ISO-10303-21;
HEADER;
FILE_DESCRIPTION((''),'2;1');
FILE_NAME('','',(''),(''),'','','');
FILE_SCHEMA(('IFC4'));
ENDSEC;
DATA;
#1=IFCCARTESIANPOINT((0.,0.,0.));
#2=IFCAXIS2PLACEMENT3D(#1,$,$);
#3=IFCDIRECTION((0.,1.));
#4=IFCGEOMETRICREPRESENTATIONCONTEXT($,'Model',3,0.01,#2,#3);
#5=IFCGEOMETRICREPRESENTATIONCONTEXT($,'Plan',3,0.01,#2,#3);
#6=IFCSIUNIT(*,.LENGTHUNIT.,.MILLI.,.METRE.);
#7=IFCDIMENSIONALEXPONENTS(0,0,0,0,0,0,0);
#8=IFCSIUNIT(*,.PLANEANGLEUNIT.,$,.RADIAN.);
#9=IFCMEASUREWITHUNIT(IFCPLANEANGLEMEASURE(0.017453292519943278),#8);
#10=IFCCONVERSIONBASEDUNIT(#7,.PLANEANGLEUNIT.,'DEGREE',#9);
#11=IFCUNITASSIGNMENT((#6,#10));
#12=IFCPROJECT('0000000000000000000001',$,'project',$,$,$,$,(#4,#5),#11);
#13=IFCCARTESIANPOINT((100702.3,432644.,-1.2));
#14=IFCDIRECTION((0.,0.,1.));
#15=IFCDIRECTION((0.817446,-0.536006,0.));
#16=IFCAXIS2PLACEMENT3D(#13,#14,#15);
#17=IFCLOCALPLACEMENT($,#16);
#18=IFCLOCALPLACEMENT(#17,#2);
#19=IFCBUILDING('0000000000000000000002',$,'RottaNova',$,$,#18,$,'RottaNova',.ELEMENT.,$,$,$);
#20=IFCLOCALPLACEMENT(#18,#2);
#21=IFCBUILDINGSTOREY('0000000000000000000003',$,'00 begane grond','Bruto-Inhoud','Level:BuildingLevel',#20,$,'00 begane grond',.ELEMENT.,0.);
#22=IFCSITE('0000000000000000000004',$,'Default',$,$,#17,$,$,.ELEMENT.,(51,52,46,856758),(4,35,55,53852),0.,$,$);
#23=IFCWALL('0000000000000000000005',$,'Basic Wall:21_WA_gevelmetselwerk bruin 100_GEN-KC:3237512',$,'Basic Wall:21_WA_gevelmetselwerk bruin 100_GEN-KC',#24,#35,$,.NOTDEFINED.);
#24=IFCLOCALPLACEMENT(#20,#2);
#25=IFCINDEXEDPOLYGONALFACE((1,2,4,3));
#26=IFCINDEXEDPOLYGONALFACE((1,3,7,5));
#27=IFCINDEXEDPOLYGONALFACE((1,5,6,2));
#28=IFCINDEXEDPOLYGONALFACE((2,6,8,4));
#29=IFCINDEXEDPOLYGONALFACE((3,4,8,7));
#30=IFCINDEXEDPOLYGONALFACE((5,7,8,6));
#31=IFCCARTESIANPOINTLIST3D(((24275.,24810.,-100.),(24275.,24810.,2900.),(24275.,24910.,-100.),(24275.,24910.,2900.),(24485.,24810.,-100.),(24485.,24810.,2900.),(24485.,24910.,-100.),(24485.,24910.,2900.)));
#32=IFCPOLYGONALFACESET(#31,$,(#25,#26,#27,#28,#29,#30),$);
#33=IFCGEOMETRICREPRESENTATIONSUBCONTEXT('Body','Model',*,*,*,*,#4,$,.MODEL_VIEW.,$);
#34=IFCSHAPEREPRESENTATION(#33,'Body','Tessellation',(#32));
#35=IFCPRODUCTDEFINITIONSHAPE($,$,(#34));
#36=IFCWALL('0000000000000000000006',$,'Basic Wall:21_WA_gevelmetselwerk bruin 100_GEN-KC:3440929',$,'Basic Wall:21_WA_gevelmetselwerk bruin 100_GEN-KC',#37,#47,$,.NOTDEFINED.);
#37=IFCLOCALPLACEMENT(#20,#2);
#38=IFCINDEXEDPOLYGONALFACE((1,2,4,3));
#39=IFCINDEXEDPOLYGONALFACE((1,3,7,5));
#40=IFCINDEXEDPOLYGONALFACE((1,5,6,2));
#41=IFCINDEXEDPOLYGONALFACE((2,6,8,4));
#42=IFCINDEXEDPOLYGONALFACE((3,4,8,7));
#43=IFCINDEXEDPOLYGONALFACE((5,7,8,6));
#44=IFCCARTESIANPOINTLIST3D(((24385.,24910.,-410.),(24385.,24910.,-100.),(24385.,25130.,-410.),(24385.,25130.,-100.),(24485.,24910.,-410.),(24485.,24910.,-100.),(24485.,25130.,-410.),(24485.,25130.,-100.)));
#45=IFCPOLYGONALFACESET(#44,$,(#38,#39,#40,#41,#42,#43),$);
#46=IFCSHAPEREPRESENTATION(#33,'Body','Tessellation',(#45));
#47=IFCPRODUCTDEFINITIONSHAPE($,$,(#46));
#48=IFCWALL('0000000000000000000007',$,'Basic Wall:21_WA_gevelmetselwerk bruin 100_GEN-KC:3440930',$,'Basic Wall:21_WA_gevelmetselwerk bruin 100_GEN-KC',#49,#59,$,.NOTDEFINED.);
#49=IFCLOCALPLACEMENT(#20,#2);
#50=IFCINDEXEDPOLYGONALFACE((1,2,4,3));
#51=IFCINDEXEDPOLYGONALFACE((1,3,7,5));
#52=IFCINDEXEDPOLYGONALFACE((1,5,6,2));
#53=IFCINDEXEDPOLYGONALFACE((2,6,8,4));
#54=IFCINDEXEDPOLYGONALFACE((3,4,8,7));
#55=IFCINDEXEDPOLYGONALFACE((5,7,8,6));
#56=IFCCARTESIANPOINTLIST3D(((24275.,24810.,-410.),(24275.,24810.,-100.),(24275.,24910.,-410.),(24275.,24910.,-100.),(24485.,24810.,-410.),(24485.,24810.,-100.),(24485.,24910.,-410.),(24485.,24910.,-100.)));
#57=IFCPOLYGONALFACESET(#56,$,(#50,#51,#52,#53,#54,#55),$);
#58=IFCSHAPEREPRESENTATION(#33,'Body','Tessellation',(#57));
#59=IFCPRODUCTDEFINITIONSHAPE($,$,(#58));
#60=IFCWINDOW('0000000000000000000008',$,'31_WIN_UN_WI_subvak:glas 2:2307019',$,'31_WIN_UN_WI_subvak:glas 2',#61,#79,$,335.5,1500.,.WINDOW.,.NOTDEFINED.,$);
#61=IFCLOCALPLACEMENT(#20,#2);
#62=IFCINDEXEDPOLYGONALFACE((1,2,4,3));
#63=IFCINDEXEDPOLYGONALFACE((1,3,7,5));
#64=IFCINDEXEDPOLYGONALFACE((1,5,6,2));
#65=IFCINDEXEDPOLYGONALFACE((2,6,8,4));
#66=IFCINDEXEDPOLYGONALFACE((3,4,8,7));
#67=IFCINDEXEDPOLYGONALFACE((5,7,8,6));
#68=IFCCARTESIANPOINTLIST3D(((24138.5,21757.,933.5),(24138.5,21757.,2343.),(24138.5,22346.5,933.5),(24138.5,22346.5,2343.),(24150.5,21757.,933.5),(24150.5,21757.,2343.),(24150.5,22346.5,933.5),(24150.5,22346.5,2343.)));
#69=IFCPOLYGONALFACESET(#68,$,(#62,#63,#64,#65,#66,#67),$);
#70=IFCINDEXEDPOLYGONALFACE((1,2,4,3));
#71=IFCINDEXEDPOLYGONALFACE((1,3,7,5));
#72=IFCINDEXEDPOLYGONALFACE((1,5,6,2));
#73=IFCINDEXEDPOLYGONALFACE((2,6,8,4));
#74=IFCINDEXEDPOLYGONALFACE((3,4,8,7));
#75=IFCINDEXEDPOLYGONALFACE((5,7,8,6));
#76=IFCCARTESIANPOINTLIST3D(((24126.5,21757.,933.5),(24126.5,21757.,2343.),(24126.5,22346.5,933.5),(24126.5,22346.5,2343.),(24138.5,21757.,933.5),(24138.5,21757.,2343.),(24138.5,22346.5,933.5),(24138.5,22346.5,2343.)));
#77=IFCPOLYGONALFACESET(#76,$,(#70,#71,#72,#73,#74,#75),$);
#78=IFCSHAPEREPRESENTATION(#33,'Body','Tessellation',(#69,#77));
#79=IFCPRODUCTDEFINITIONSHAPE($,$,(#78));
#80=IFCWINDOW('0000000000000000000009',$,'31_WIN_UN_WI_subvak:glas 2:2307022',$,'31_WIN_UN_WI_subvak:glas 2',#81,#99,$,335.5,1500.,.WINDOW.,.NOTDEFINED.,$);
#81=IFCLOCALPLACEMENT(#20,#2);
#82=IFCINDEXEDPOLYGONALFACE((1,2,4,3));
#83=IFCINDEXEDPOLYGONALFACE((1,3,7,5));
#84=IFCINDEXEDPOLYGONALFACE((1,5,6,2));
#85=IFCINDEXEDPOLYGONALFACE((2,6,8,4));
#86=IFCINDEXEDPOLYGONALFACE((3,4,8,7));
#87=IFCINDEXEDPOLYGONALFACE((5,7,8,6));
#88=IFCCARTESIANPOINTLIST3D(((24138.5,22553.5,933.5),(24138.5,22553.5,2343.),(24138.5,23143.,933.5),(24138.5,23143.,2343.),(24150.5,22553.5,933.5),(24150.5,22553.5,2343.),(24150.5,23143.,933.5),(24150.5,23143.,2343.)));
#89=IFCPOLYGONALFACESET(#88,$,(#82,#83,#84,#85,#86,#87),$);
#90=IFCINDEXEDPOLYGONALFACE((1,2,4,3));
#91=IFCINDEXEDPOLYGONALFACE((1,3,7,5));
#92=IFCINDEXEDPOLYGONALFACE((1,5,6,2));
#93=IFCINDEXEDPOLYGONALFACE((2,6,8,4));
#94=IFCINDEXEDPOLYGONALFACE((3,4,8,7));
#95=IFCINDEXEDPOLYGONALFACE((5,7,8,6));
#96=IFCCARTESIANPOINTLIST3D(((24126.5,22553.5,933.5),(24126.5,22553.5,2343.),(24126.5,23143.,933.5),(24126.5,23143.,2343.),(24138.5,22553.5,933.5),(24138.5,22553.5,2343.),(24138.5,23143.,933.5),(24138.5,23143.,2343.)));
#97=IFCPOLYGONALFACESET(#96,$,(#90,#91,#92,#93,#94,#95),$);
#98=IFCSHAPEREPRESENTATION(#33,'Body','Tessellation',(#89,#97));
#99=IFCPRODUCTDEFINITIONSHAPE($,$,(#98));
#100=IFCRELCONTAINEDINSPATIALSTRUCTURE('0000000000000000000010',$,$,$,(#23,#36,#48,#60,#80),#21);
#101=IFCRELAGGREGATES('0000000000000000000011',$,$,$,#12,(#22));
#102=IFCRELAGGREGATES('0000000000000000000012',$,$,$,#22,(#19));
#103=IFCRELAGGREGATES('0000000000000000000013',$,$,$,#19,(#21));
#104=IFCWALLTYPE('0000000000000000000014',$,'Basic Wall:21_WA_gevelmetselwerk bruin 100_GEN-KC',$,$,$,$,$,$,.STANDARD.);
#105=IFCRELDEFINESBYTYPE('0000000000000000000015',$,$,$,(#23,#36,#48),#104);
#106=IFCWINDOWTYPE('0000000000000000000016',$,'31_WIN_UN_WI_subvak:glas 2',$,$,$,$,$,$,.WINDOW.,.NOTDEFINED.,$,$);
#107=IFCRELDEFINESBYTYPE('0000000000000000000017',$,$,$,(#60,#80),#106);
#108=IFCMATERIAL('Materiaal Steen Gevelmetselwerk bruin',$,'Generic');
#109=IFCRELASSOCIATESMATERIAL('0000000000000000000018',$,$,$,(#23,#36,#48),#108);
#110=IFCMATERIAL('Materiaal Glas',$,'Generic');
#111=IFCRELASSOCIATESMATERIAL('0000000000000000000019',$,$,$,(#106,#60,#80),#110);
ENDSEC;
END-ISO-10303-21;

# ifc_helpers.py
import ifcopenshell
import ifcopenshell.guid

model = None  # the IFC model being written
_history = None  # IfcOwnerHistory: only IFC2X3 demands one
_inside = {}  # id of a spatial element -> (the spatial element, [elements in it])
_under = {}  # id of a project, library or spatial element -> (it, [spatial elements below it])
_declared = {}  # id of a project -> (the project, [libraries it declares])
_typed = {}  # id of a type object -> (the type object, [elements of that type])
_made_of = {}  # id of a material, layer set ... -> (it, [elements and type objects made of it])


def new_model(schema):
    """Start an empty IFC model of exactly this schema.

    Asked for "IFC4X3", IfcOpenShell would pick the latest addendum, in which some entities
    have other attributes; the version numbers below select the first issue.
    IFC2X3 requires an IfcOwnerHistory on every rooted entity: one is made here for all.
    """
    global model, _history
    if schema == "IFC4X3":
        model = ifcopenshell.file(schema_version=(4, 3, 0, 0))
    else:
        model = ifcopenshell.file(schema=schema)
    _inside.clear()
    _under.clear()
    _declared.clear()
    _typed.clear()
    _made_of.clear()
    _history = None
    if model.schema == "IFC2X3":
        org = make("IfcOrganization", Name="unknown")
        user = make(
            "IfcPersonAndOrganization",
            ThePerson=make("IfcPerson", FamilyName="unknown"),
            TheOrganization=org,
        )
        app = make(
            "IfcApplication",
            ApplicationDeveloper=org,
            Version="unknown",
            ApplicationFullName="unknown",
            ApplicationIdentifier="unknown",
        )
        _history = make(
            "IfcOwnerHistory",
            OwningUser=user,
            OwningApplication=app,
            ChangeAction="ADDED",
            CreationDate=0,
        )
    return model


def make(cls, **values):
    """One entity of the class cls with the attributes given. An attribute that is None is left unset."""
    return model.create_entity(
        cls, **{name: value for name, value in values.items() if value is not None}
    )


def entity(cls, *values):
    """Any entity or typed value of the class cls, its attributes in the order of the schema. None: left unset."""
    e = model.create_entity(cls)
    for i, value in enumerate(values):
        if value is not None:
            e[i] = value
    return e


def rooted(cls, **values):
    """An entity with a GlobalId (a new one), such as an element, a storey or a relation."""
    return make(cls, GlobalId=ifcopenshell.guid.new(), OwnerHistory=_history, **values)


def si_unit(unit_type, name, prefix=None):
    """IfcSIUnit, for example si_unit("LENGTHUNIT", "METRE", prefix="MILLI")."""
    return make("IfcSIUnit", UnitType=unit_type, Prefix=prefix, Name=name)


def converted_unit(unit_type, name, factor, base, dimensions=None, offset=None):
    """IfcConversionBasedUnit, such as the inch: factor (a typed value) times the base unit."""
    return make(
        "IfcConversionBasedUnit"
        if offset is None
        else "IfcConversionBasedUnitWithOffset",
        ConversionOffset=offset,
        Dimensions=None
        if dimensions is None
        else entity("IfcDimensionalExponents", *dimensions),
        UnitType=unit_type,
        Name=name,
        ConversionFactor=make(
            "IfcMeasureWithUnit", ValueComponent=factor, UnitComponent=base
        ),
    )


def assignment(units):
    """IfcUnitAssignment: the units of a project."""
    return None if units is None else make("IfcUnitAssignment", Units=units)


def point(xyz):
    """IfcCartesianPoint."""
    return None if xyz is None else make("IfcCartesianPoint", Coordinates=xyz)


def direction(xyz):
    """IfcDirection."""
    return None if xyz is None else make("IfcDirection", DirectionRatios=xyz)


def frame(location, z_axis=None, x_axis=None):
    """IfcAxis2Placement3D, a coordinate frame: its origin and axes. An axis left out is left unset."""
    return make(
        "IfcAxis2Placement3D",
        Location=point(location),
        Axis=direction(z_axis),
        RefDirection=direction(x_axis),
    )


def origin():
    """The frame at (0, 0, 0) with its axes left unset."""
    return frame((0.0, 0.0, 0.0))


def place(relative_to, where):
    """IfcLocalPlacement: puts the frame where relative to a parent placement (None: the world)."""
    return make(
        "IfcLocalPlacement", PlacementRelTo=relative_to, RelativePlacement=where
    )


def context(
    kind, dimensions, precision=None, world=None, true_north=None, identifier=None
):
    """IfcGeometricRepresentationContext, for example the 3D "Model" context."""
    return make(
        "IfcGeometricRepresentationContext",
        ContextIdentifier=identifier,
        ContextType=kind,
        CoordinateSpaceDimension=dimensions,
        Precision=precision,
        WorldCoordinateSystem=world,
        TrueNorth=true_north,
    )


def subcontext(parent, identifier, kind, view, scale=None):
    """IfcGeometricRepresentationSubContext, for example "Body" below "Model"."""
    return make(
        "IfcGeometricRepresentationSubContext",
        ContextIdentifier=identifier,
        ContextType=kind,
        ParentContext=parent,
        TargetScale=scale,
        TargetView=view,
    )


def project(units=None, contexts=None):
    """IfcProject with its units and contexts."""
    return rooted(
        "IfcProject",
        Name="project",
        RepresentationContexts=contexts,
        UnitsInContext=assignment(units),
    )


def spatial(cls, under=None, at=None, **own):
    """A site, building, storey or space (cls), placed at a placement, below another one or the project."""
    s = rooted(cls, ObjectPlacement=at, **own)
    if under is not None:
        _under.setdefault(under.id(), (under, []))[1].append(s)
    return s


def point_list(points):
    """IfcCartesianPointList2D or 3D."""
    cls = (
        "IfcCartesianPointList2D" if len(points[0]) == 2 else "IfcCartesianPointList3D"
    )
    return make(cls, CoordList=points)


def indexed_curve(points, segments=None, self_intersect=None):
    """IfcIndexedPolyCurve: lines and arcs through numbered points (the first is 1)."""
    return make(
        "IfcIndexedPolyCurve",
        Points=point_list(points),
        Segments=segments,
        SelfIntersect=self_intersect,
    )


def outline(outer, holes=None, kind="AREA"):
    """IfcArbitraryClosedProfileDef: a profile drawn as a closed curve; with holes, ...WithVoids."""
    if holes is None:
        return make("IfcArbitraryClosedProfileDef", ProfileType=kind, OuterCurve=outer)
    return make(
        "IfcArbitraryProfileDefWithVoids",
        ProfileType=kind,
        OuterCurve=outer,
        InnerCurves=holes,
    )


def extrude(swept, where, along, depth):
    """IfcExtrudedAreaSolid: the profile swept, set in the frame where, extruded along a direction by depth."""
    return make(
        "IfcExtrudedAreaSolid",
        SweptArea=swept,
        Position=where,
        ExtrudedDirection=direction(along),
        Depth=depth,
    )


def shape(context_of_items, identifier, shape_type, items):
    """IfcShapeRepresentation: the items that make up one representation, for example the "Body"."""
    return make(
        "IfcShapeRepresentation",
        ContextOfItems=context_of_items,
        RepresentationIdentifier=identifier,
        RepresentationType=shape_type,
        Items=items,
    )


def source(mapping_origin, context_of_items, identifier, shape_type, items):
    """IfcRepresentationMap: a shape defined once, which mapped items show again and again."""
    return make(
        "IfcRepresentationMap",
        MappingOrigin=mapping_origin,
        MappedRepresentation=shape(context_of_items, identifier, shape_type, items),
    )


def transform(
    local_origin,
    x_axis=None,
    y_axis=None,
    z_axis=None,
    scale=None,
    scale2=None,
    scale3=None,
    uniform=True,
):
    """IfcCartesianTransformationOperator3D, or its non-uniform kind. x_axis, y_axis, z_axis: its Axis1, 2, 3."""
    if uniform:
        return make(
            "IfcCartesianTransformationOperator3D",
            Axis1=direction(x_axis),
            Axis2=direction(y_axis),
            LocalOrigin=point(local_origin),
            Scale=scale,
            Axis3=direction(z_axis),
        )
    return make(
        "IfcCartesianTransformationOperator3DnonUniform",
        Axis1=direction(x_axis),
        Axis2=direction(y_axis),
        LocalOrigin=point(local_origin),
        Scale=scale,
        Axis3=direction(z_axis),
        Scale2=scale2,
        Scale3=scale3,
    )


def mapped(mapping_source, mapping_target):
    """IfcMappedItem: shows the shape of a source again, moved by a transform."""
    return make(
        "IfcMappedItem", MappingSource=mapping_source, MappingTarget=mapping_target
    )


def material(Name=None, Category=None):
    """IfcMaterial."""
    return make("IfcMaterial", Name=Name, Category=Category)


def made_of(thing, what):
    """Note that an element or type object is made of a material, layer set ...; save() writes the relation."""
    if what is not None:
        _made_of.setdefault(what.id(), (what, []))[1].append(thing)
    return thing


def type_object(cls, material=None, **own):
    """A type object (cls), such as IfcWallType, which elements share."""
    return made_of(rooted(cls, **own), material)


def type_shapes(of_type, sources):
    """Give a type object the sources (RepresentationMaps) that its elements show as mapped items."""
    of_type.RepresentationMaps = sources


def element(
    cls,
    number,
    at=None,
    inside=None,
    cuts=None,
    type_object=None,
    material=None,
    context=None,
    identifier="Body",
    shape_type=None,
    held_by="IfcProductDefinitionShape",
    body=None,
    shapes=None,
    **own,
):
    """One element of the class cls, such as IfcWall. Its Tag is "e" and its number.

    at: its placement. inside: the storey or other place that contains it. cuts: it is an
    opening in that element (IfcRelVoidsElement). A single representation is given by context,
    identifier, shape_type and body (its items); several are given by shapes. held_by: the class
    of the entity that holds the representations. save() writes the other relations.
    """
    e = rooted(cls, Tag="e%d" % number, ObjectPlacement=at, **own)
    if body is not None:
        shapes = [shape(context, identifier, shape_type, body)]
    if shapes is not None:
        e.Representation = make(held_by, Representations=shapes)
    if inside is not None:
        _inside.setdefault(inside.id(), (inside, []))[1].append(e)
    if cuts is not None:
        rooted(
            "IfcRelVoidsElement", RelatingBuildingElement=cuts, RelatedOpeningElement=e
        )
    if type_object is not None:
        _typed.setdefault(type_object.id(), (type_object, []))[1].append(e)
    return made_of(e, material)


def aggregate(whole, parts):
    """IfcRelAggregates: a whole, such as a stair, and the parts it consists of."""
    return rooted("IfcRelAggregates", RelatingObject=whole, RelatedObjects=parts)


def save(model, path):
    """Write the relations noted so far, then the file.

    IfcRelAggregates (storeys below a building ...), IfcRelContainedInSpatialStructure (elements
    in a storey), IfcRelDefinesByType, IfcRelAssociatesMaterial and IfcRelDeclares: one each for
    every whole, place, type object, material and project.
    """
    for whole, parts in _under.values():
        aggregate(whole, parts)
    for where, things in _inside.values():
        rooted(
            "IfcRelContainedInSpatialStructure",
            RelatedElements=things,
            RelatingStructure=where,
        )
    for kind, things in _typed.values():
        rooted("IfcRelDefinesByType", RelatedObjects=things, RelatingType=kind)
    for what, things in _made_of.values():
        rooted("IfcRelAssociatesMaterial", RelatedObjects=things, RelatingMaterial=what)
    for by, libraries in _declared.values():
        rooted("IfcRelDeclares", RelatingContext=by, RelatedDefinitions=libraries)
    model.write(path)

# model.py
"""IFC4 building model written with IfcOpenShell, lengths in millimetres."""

from ifc_helpers import new_model, entity, si_unit, converted_unit, direction, frame, origin, place, context, subcontext, project, spatial, indexed_curve, outline, extrude, source, transform, mapped, material, type_object, type_shapes, element, save


model = new_model("IFC4")

# Units and contexts
model_context = context("Model", 3, precision=0.01, world=origin(), true_north=direction((0.0, 1.0)))
plan_context = context("Plan", 3, precision=0.01, world=origin(), true_north=direction((0.0, 1.0)))
body_context = subcontext(model_context, "Body", "Model", "MODEL_VIEW")
ifc_project = project(units=[si_unit("LENGTHUNIT", "METRE", prefix="MILLI"), converted_unit("PLANEANGLEUNIT", "DEGREE", entity("IfcPlaneAngleMeasure", 0.017453292519943278), si_unit("PLANEANGLEUNIT", "RADIAN"), dimensions=[0, 0, 0, 0, 0, 0, 0])], contexts=[model_context, plan_context])

# Site, building, storey
site_placement = place(None, frame((100702.3, 432644.0, -1.2), z_axis=(0.0, 0.0, 1.0), x_axis=(0.817446, -0.536006, 0.0)))
site = spatial("IfcSite", under=ifc_project, at=site_placement, Name="Default", CompositionType="ELEMENT", RefLatitude=(51, 52, 46, 856758), RefLongitude=(4, 35, 55, 53852), RefElevation=0.0)
building_placement = place(site_placement, origin())
building = spatial("IfcBuilding", under=site, at=building_placement, Name="RottaNova", LongName="RottaNova", CompositionType="ELEMENT")
storey_placement = place(building_placement, origin())
storey = spatial("IfcBuildingStorey", under=building, at=storey_placement, Name="00 begane grond", Description="Bruto-Inhoud", ObjectType="Level:BuildingLevel", LongName="00 begane grond", CompositionType="ELEMENT", Elevation=0.0)

# Shared definitions
ifc_material_1 = material(Name="Materiaal Glas", Category="Generic")

# Walls
ifc_material_2 = material(Name="Materiaal Steen Gevelmetselwerk bruin", Category="Generic")
wall_type_1 = type_object("IfcWallType", Name="Basic Wall:21_WA_gevelmetselwerk bruin 100_GEN-KC", PredefinedType="STANDARD")
wall_1_placement = place(storey_placement, frame((24485.0, 24860.0, -100.0), z_axis=(0.0, 0.0, 1.0), x_axis=(-1.0, 0.0, 0.0)))
element("IfcWall", 1, at=wall_1_placement, inside=storey, type_object=wall_type_1, material=ifc_material_2, Name="Basic Wall:21_WA_gevelmetselwerk bruin 100_GEN-KC:3237512", ObjectType="Basic Wall:21_WA_gevelmetselwerk bruin 100_GEN-KC", PredefinedType="NOTDEFINED", context=body_context, shape_type="SweptSolid", body=[
    extrude(outline(indexed_curve([(210.0, 50.0), (0.0, 50.0), (0.0, -50.0), (210.0, -50.0), (210.0, 50.0)], self_intersect=False)), origin(), (0.0, 0.0, 1.0), 3000.0),
])
wall_2_placement = place(storey_placement, frame((24435.0, 25130.0, -410.0), z_axis=(0.0, 0.0, 1.0), x_axis=(0.0, -1.0, 0.0)))
element("IfcWall", 2, at=wall_2_placement, inside=storey, type_object=wall_type_1, material=ifc_material_2, Name="Basic Wall:21_WA_gevelmetselwerk bruin 100_GEN-KC:3440929", ObjectType="Basic Wall:21_WA_gevelmetselwerk bruin 100_GEN-KC", PredefinedType="NOTDEFINED", context=body_context, shape_type="SweptSolid", body=[
    extrude(outline(indexed_curve([(220.0, 50.0), (0.0, 50.0), (0.0, -50.0), (220.0, -50.0), (220.0, 50.0)], self_intersect=False)), origin(), (0.0, 0.0, 1.0), 310.0),
])
wall_3_placement = place(storey_placement, frame((24485.0, 24860.0, -410.0), z_axis=(0.0, 0.0, 1.0), x_axis=(-1.0, 0.0, 0.0)))
element("IfcWall", 3, at=wall_3_placement, inside=storey, type_object=wall_type_1, material=ifc_material_2, Name="Basic Wall:21_WA_gevelmetselwerk bruin 100_GEN-KC:3440930", ObjectType="Basic Wall:21_WA_gevelmetselwerk bruin 100_GEN-KC", PredefinedType="NOTDEFINED", context=body_context, shape_type="SweptSolid", body=[
    extrude(outline(indexed_curve([(210.0, 50.0), (0.0, 50.0), (0.0, -50.0), (210.0, -50.0), (210.0, 50.0)], self_intersect=False)), origin(), (0.0, 0.0, 1.0), 310.0),
])

# Windows
window_type = type_object("IfcWindowType", Name="31_WIN_UN_WI_subvak:glas 2", PartitioningType="NOTDEFINED", PredefinedType="WINDOW", material=ifc_material_1)
shared_shape_1 = source(origin(), body_context, "Body", "SweptSolid", [
    extrude(outline(indexed_curve([(-294.7, -6.0), (294.7, -6.0), (294.7, 6.0), (-294.7, 6.0), (-294.7, -6.0)], self_intersect=False)), frame((0.0, -6.0, 0.0)), (0.0, 0.0, 1.0), 1409.5),
    extrude(outline(indexed_curve([(-294.8, -6.0), (294.8, -6.0), (294.8, 6.0), (-294.8, 6.0), (-294.8, -6.0)], self_intersect=False)), frame((0.0, 6.0, 0.0)), (0.0, 0.0, 1.0), 1409.5),
])
type_shapes(window_type, [shared_shape_1])
for number, where, z_axis, x_axis, name in (
    (4, (24138.5, 22051.7, 933.5), (0.0, 0.0, 1.0), (0.0, 1.0, 0.0), "31_WIN_UN_WI_subvak:glas 2:2307019"),
    (5, (24138.5, 22848.2, 933.5), (0.0, 0.0, 1.0), (0.0, 1.0, 0.0), "31_WIN_UN_WI_subvak:glas 2:2307022"),
):
    element("IfcWindow", number, at=place(storey_placement, frame(where, z_axis=z_axis, x_axis=x_axis)), inside=storey, type_object=window_type, material=ifc_material_1, Name=name, ObjectType="31_WIN_UN_WI_subvak:glas 2", OverallHeight=335.5, OverallWidth=1500.0, PartitioningType="NOTDEFINED", PredefinedType="WINDOW", context=body_context, shape_type="MappedRepresentation", body=[
        mapped(shared_shape_1, transform((0.0, 0.0, 0.0), scale=1.0)),
    ])

save(model, "model.ifc")
